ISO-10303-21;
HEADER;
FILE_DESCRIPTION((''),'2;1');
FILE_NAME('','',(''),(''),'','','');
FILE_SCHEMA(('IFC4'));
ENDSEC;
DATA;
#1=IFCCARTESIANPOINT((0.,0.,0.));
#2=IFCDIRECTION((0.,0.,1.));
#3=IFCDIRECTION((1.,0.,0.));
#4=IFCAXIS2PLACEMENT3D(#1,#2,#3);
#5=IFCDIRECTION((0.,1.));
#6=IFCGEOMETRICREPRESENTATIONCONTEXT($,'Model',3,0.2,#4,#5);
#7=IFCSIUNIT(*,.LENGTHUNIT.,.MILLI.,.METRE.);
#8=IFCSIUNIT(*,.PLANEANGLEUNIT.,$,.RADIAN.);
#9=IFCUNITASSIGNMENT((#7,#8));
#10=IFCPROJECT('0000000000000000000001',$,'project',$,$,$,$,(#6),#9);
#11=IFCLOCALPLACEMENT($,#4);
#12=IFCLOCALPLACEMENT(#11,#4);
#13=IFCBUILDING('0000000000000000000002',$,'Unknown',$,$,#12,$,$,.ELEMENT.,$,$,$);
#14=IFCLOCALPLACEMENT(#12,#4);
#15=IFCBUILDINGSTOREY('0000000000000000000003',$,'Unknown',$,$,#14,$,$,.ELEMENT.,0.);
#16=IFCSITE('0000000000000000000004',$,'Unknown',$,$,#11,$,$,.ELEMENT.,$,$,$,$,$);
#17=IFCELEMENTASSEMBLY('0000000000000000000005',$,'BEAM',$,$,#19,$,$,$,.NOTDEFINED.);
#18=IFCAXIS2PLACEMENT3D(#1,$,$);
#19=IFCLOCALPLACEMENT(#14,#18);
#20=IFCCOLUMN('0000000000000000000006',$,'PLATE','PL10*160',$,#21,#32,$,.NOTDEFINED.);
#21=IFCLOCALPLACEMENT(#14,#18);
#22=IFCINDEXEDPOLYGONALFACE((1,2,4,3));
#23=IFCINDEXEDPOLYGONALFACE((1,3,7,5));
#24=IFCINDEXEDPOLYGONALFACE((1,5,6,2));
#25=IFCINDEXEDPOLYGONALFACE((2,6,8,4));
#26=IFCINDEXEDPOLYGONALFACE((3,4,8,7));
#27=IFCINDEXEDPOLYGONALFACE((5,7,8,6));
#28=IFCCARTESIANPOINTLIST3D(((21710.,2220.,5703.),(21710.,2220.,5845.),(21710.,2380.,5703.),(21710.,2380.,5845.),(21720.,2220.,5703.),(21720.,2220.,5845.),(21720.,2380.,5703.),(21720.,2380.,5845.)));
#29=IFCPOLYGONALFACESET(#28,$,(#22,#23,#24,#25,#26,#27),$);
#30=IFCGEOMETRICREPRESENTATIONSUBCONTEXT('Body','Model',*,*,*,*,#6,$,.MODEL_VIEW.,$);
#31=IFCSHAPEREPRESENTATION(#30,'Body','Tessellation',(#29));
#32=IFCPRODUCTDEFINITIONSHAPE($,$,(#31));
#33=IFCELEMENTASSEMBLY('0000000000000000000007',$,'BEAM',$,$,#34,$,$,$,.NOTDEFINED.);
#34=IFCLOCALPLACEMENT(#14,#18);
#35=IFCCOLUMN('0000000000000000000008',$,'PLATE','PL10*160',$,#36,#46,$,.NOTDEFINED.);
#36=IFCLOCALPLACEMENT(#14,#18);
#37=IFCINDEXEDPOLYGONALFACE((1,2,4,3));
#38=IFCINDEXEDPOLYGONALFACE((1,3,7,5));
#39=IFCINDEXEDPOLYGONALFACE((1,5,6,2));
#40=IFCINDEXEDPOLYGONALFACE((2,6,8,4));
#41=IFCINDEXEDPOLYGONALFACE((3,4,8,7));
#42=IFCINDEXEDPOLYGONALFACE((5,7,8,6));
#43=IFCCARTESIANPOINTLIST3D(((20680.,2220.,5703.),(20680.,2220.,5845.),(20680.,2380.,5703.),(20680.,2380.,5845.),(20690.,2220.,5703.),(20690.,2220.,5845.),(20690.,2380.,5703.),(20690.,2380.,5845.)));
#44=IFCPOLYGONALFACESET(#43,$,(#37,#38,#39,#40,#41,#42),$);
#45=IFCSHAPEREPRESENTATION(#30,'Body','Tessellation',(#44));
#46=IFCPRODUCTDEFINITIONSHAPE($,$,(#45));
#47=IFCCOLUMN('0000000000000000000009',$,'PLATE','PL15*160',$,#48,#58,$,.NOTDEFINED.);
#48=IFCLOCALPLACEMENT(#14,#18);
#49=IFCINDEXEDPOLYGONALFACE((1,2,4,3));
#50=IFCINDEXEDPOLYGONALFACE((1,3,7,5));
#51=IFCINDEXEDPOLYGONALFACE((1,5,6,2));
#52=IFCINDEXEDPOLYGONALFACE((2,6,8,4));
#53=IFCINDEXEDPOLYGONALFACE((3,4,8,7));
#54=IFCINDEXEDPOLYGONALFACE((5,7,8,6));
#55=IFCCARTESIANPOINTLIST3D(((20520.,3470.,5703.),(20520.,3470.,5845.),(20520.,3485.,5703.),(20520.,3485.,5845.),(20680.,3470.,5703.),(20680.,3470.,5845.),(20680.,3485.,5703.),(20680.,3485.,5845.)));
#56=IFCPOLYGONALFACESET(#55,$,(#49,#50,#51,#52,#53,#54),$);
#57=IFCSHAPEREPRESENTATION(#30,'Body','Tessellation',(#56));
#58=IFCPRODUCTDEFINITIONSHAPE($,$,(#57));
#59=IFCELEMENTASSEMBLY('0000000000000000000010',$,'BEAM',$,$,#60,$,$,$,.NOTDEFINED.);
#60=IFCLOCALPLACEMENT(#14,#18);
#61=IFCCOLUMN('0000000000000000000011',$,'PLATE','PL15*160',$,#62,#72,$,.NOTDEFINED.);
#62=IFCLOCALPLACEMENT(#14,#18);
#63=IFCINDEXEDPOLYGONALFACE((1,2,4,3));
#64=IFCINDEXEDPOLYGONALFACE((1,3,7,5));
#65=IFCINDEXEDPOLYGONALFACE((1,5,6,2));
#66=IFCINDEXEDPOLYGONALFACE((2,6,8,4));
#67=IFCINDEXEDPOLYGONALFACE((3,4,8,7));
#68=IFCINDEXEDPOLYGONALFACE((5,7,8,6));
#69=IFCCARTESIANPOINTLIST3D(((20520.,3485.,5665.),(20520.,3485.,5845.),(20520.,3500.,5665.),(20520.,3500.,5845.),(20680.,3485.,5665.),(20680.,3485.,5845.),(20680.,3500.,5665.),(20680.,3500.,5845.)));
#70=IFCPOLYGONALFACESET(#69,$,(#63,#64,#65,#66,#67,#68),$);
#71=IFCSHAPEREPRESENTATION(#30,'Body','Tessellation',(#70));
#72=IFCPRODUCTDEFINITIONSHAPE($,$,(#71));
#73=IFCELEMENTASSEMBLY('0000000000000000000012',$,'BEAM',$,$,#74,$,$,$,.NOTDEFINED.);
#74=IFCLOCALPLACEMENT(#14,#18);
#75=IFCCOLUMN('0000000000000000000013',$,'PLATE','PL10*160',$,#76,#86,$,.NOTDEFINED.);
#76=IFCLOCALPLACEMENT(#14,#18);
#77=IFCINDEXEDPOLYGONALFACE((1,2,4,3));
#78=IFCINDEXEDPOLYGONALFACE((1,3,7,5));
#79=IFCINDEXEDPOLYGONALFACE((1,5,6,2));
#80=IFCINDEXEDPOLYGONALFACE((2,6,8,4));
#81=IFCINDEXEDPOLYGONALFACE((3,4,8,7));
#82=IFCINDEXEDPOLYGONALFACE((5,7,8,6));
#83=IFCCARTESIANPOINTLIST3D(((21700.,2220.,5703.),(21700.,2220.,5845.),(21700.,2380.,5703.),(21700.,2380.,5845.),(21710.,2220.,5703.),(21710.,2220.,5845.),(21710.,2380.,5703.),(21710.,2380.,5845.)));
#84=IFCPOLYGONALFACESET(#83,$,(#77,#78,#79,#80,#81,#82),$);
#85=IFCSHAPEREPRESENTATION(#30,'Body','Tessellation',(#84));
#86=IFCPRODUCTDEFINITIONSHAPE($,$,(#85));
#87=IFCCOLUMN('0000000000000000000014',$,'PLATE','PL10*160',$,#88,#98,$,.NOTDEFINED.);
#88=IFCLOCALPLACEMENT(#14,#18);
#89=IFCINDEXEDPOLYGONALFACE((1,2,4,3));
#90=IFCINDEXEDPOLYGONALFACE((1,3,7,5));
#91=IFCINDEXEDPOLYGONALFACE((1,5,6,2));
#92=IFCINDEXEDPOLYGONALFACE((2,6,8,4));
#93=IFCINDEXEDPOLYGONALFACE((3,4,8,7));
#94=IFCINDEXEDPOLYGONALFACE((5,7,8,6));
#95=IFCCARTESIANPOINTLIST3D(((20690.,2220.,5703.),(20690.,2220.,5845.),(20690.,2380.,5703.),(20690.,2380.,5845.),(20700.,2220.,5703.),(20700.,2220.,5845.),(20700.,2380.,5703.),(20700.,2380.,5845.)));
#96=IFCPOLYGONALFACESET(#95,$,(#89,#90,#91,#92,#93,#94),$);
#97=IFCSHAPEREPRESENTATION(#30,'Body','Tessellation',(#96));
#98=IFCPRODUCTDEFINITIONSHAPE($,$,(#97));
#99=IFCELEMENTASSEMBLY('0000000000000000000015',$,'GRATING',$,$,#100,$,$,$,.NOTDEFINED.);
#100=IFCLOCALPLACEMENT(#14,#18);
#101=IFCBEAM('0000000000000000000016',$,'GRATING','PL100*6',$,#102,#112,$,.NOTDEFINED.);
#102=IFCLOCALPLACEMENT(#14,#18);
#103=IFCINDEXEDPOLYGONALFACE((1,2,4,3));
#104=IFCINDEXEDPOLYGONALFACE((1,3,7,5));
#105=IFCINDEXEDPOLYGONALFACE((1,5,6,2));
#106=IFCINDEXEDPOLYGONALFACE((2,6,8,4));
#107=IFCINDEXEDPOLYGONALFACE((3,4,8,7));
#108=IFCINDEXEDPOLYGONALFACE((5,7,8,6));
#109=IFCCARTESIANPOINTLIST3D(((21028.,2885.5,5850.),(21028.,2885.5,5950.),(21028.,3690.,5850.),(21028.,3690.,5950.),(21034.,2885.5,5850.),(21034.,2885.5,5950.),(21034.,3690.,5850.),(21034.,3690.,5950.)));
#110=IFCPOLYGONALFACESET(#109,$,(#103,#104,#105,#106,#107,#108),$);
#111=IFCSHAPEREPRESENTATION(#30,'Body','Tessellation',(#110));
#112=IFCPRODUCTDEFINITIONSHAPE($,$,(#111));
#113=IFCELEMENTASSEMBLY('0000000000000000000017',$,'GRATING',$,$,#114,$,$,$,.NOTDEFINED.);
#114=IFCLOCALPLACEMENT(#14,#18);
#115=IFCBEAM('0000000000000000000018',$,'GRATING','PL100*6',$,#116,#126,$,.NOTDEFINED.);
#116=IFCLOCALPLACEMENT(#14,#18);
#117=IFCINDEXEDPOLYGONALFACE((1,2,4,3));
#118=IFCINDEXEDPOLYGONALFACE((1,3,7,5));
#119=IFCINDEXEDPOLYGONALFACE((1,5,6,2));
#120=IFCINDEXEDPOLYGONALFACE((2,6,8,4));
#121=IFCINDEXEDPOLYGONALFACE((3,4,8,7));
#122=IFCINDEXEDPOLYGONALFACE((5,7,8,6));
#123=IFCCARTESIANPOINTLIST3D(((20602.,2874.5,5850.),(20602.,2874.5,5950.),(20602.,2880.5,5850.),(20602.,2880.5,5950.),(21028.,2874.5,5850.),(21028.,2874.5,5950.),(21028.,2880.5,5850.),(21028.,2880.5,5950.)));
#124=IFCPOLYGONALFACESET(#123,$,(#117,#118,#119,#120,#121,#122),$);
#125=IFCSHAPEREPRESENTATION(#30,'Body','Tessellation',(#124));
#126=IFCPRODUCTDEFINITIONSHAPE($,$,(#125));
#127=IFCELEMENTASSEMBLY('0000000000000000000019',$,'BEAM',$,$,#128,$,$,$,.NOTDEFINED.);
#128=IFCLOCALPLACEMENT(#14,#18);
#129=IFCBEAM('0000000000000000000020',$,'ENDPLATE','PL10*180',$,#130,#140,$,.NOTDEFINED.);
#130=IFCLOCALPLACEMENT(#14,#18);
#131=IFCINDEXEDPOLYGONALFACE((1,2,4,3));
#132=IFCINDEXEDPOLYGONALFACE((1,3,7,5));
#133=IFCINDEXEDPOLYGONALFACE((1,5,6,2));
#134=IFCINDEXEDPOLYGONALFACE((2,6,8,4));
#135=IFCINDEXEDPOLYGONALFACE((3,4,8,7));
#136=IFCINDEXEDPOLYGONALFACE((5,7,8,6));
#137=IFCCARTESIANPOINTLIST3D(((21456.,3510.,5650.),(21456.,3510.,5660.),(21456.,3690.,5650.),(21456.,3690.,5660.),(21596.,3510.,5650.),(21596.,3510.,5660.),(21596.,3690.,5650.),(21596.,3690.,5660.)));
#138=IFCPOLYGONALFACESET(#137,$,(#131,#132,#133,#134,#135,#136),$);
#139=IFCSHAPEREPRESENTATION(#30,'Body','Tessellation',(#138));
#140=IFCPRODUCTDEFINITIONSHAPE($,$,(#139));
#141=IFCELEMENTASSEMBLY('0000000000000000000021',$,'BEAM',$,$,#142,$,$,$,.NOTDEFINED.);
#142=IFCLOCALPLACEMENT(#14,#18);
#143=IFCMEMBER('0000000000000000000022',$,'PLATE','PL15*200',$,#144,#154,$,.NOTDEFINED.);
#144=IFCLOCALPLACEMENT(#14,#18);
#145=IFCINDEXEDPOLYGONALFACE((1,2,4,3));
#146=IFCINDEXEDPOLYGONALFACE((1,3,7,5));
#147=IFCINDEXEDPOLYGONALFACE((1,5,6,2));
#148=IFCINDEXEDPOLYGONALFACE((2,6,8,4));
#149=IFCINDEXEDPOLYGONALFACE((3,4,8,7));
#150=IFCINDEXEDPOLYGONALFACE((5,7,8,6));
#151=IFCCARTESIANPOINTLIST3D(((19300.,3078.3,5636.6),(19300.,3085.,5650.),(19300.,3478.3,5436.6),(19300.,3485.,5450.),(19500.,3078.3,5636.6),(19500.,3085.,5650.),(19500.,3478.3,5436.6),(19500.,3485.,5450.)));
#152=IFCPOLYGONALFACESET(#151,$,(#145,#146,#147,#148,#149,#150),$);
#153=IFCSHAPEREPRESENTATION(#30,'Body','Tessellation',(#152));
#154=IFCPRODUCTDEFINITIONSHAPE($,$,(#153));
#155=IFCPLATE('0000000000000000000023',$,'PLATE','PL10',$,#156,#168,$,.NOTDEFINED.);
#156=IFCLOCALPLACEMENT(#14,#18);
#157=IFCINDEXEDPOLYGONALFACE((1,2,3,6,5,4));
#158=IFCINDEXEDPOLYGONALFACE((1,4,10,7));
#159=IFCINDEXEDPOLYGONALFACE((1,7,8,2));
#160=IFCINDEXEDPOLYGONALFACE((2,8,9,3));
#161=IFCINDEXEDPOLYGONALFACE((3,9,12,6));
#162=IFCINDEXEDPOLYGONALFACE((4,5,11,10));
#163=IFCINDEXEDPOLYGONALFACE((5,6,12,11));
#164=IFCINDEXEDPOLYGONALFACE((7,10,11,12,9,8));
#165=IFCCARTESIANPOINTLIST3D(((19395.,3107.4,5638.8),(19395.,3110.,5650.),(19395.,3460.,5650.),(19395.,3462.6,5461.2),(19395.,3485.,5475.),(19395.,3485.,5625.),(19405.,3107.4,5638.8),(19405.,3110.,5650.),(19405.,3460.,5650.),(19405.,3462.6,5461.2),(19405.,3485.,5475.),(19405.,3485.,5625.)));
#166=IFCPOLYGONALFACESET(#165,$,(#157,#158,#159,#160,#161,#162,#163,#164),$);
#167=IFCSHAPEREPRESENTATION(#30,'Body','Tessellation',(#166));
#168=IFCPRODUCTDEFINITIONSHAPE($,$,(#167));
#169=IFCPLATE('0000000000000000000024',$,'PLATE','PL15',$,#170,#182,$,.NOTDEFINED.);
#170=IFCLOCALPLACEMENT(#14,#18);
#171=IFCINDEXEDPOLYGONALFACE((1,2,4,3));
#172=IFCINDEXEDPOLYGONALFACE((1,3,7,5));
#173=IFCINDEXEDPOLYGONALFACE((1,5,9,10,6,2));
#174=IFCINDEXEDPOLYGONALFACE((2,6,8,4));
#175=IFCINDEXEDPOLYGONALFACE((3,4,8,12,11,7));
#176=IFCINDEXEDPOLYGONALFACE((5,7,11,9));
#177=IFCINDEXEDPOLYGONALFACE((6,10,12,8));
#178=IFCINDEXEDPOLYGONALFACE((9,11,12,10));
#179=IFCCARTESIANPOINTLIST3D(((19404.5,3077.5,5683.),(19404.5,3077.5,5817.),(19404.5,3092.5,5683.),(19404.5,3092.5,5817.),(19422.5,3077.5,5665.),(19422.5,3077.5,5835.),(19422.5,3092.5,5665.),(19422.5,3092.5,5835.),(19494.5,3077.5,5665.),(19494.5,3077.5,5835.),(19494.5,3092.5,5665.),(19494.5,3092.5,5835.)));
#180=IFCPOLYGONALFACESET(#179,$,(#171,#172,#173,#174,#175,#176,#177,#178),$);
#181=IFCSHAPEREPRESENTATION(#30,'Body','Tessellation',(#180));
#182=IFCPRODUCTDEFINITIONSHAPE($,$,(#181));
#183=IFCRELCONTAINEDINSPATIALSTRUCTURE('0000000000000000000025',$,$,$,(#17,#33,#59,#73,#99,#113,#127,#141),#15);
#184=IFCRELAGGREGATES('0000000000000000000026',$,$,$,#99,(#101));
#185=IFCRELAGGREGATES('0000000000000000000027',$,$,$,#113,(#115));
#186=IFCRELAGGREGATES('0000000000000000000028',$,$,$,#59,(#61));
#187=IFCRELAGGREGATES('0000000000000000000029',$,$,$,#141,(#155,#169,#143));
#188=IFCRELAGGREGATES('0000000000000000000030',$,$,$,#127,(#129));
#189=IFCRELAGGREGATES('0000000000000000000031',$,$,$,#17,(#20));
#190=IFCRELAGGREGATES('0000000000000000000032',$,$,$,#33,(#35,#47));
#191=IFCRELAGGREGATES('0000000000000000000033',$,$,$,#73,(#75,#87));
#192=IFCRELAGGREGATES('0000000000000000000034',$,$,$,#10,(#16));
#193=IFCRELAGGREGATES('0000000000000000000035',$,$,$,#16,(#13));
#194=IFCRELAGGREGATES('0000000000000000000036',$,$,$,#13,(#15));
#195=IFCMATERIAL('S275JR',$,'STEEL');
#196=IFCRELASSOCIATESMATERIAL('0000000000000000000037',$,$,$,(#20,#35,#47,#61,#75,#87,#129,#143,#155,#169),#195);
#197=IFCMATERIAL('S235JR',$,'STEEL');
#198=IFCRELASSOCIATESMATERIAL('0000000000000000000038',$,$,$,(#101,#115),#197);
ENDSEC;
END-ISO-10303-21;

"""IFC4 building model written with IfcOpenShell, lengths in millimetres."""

from ifc_helpers import new_model, si_unit, direction, frame, origin_with_axes, place, context, subcontext, project, spatial, line, indexed_curve, outline, extrude, material, element, aggregate, save


model = new_model("IFC4")

# Units and contexts
model_context = context("Model", 3, precision=0.2, world=origin_with_axes(), true_north=direction((0.0, 1.0)))
body_context = subcontext(model_context, "Body", "Model", "MODEL_VIEW")
ifc_project = project(units=[si_unit("LENGTHUNIT", "METRE", prefix="MILLI"), si_unit("PLANEANGLEUNIT", "RADIAN")], contexts=[model_context])

# Site, building, storey
site_placement = place(None, origin_with_axes())
site = spatial("IfcSite", under=ifc_project, at=site_placement, Name="Unknown", CompositionType="ELEMENT")
building_placement = place(site_placement, origin_with_axes())
building = spatial("IfcBuilding", under=site, at=building_placement, Name="Unknown", CompositionType="ELEMENT")
storey_placement = place(building_placement, origin_with_axes())
storey = spatial("IfcBuildingStorey", under=building, at=storey_placement, Name="Unknown", CompositionType="ELEMENT", Elevation=0.0)

# Element assembly, column
assembly_1_placement = place(storey_placement, frame((21800.0, 3600.0, 5774.0), z_axis=(-1.0, 0.0, 0.0), x_axis=(-0.000002, -1.0, 0.0)))
assembly_1 = element("IfcElementAssembly", 1, at=assembly_1_placement, inside=storey, Name="BEAM", PredefinedType="NOTDEFINED")
ifc_material_1 = material(Name="S275JR", Category="STEEL")
column_1_placement = place(assembly_1_placement, frame((1300.0, -71.0, 85.0), z_axis=(0.0, 0.0, 1.0), x_axis=(0.0, 1.0, 0.0)))
column_1 = element("IfcColumn", 2, at=column_1_placement, material=ifc_material_1, Name="PLATE", Description="PL10*160", PredefinedType="NOTDEFINED", context=body_context, shape_type="SolidModel", body=[
    extrude(outline(indexed_curve([(-5.0, -80.0), (5.0, -80.0), (5.0, 80.0), (-5.0, 80.0)], segments=[line(1, 2, 3, 4, 1)])), frame((0.0, 0.0, 0.0), z_axis=(-1.0, 0.0, 0.0), x_axis=(0.0, 0.0, 1.0)), (0.0, -0.000002, -1.0), 142.0),
])

# Element assembly, columns
assembly_2_placement = place(storey_placement, frame((20600.0, 3600.0, 5774.0), z_axis=(-1.0, 0.0, 0.0), x_axis=(-0.000002, -1.0, 0.0)))
assembly_2 = element("IfcElementAssembly", 3, at=assembly_2_placement, inside=storey, Name="BEAM", PredefinedType="NOTDEFINED")
column_2_placement = place(assembly_2_placement, frame((1300.0, -71.0, -85.0), z_axis=(0.0, -0.000002, -1.0), x_axis=(0.0, 1.0, 0.0)))
column_2 = element("IfcColumn", 4, at=column_2_placement, material=ifc_material_1, Name="PLATE", Description="PL10*160", PredefinedType="NOTDEFINED", context=body_context, shape_type="SolidModel", body=[
    extrude(outline(indexed_curve([(-5.0, -80.0), (5.0, -80.0), (5.0, 80.0), (-5.0, 80.0)], segments=[line(1, 2, 3, 4, 1)])), frame((0.0, 0.0, 0.0), z_axis=(-1.0, 0.0, 0.0), x_axis=(0.0, 0.0, 1.0)), (0.0, -0.000002, -1.0), 142.0),
])
column_3_placement = place(assembly_2_placement, frame((122.5, -71.0, 0.0), z_axis=(1.0, 0.0, 0.0), x_axis=(0.0, 1.0, 0.0)))
column_3 = element("IfcColumn", 5, at=column_3_placement, material=ifc_material_1, Name="PLATE", Description="PL15*160", PredefinedType="NOTDEFINED", context=body_context, shape_type="SolidModel", body=[
    extrude(outline(indexed_curve([(-7.5, -80.0), (7.5, -80.0), (7.5, 80.0), (-7.5, 80.0)], segments=[line(1, 2, 3, 4, 1)])), frame((0.0, 0.0, 0.0), z_axis=(-1.0, 0.0, 0.0), x_axis=(0.0, 0.0, 1.0)), (0.0, -0.000002, -1.0), 142.0),
])

# Element assembly, column
assembly_3_placement = place(storey_placement, frame((19400.0, 3600.0, 5755.0), z_axis=(-0.000002, -1.0, 0.0), x_axis=(1.0, 0.0, 0.0)))
assembly_3 = element("IfcElementAssembly", 6, at=assembly_3_placement, inside=storey, Name="BEAM", PredefinedType="NOTDEFINED")
column_4_placement = place(assembly_3_placement, frame((1200.0, -90.0, 107.5), z_axis=(0.0, 0.0, 1.0), x_axis=(0.0, 1.0, 0.0)))
column_4 = element("IfcColumn", 7, at=column_4_placement, material=ifc_material_1, Name="PLATE", Description="PL15*160", PredefinedType="NOTDEFINED", context=body_context, shape_type="SolidModel", body=[
    extrude(outline(indexed_curve([(-7.5, -80.0), (7.5, -80.0), (7.5, 80.0), (-7.5, 80.0)], segments=[line(1, 2, 3, 4, 1)])), frame((0.0, 0.0, 0.0), z_axis=(-1.0, 0.0, 0.0), x_axis=(0.0, 0.0, 1.0)), (0.0, -0.000002, -1.0), 180.0),
])

# Element assembly, columns
assembly_4_placement = place(storey_placement, frame((20600.0, 2300.0, 5774.0), z_axis=(-0.000002, -1.0, 0.0), x_axis=(1.0, 0.0, 0.0)))
assembly_4 = element("IfcElementAssembly", 8, at=assembly_4_placement, inside=storey, Name="BEAM", PredefinedType="NOTDEFINED")
column_5_placement = place(assembly_4_placement, frame((1105.0, -71.0, 0.0), z_axis=(-1.0, 0.0, 0.0), x_axis=(0.0, 1.0, 0.0)))
column_5 = element("IfcColumn", 9, at=column_5_placement, material=ifc_material_1, Name="PLATE", Description="PL10*160", PredefinedType="NOTDEFINED", context=body_context, shape_type="SolidModel", body=[
    extrude(outline(indexed_curve([(-5.0, -80.0), (5.0, -80.0), (5.0, 80.0), (-5.0, 80.0)], segments=[line(1, 2, 3, 4, 1)])), frame((0.0, 0.0, 0.0), z_axis=(-1.0, 0.0, 0.0), x_axis=(0.0, 0.0, 1.0)), (0.0, -0.000002, -1.0), 142.0),
])
column_6_placement = place(assembly_4_placement, frame((95.0, -71.0, 0.0), z_axis=(1.0, 0.0, 0.0), x_axis=(0.0, 1.0, 0.0)))
column_6 = element("IfcColumn", 10, at=column_6_placement, material=ifc_material_1, Name="PLATE", Description="PL10*160", PredefinedType="NOTDEFINED", context=body_context, shape_type="SolidModel", body=[
    extrude(outline(indexed_curve([(-5.0, -80.0), (5.0, -80.0), (5.0, 80.0), (-5.0, 80.0)], segments=[line(1, 2, 3, 4, 1)])), frame((0.0, 0.0, 0.0), z_axis=(-1.0, 0.0, 0.0), x_axis=(0.0, 0.0, 1.0)), (0.0, -0.000002, -1.0), 142.0),
])

# Element assemblies, beams
assembly_5_placement = place(storey_placement, frame((21034.0, 3690.0, 5865.0), z_axis=(0.0, -0.000002, -1.0), x_axis=(1.0, 0.0, 0.0)))
assembly_5 = element("IfcElementAssembly", 11, at=assembly_5_placement, inside=storey, Name="GRATING", PredefinedType="NOTDEFINED")
ifc_material_2 = material(Name="S235JR", Category="STEEL")
beam_1_placement = place(assembly_5_placement, frame((-3.0, 804.5, -35.0), z_axis=(1.0, 0.0, 0.0), x_axis=(0.0, -1.0, 0.000002)))
beam_1 = element("IfcBeam", 12, at=beam_1_placement, material=ifc_material_2, Name="GRATING", Description="PL100*6", PredefinedType="NOTDEFINED", context=body_context, shape_type="SolidModel", body=[
    extrude(outline(indexed_curve([(-3.0, -50.0), (3.0, -50.0), (3.0, 50.0), (-3.0, 50.0)], segments=[line(1, 2, 3, 4, 1)])), frame((0.0, 0.0, 0.0), z_axis=(-1.0, 0.0, 0.0), x_axis=(0.0, 0.0, 1.0)), (0.0, -0.000002, -1.0), 804.5),
])
aggregate(assembly_5, [beam_1])
assembly_6_placement = place(storey_placement, frame((20602.0, 2874.5, 5865.0), z_axis=(0.0, -0.000002, -1.0), x_axis=(1.0, 0.0, 0.0)))
assembly_6 = element("IfcElementAssembly", 13, at=assembly_6_placement, inside=storey, Name="GRATING", PredefinedType="NOTDEFINED")
beam_2_placement = place(assembly_6_placement, frame((0.0, -3.0, -35.0), z_axis=(0.0, 1.0, 0.0), x_axis=(1.0, 0.0, 0.0)))
beam_2 = element("IfcBeam", 14, at=beam_2_placement, material=ifc_material_2, Name="GRATING", Description="PL100*6", PredefinedType="NOTDEFINED", context=body_context, shape_type="SolidModel", body=[
    extrude(outline(indexed_curve([(-3.0, -50.0), (3.0, -50.0), (3.0, 50.0), (-3.0, 50.0)], segments=[line(1, 2, 3, 4, 1)])), frame((0.0, 0.0, 0.0), z_axis=(-1.0, 0.0, 0.0), x_axis=(0.0, 0.0, 1.0)), (0.0, -0.000002, -1.0), 426.0),
])
aggregate(assembly_6, [beam_2])
assembly_7_placement = place(storey_placement, frame((21526.0, 3600.0, 5609.0), z_axis=(-0.000002, -1.0, 0.0), x_axis=(0.0, -0.000002, -1.0)))
assembly_7 = element("IfcElementAssembly", 15, at=assembly_7_placement, inside=storey, Name="BEAM", PredefinedType="NOTDEFINED")
beam_3_placement = place(assembly_7_placement, frame((-46.0, -70.0, 0.0), z_axis=(1.0, 0.0, 0.0), x_axis=(0.0, 1.0, 0.0)))
beam_3 = element("IfcBeam", 16, at=beam_3_placement, material=ifc_material_1, Name="ENDPLATE", Description="PL10*180", PredefinedType="NOTDEFINED", context=body_context, shape_type="SolidModel", body=[
    extrude(outline(indexed_curve([(-5.0, -90.0), (5.0, -90.0), (5.0, 90.0), (-5.0, 90.0)], segments=[line(1, 2, 3, 4, 1)])), frame((0.0, 0.0, 0.0), z_axis=(-1.0, 0.0, 0.0), x_axis=(0.0, 0.0, 1.0)), (0.0, -0.000002, -1.0), 140.0),
])

# Element assembly, member, plates
assembly_8_placement = place(storey_placement, frame((19400.0, 0.0, 5750.0), z_axis=(1.0, 0.0, 0.0), x_axis=(0.0, 1.0, 0.0)))
assembly_8 = element("IfcElementAssembly", 17, at=assembly_8_placement, inside=storey, Name="BEAM", PredefinedType="NOTDEFINED")
member_placement = place(assembly_8_placement, frame((3481.6, -306.7, 0.0), z_axis=(-0.447214, -0.894427, 0.0), x_axis=(-0.894427, 0.447214, 0.0)))
member = element("IfcMember", 18, at=member_placement, material=ifc_material_1, Name="PLATE", Description="PL15*200", PredefinedType="NOTDEFINED", context=body_context, shape_type="SolidModel", body=[
    extrude(outline(indexed_curve([(-7.5, -100.0), (7.5, -100.0), (7.5, 100.0), (-7.5, 100.0)], segments=[line(1, 2, 3, 4, 1)])), frame((0.0, 0.0, 0.0), z_axis=(-1.0, 0.0, 0.0), x_axis=(0.0, 0.0, 1.0)), (0.0, -0.000002, -1.0), 447.2),
])
plate_1_placement = place(assembly_8_placement, frame((3485.0, -300.0, 0.0), z_axis=(0.0, 0.0, 1.0), x_axis=(0.0, 1.0, 0.0)))
plate_1 = element("IfcPlate", 19, at=plate_1_placement, material=ifc_material_1, Name="PLATE", Description="PL10", PredefinedType="NOTDEFINED", context=body_context, shape_type="SolidModel", body=[
    extrude(outline(indexed_curve([(11.2, 22.4), (25.0, 0.0), (175.0, 0.0), (200.0, 25.0), (200.0, 375.0), (188.8, 377.6)], segments=[line(1, 2, 3, 4, 5, 6, 1)])), frame((0.0, 0.0, 5.0), z_axis=(0.0, 0.0, 1.0), x_axis=(1.0, 0.0, 0.0)), (0.0, -0.000002, -1.0), 10.0),
])
plate_2_placement = place(assembly_8_placement, frame((3085.0, -85.0, 4.5), z_axis=(-1.0, 0.0, 0.0), x_axis=(0.0, 0.0, 1.0)))
plate_2 = element("IfcPlate", 20, at=plate_2_placement, material=ifc_material_1, Name="PLATE", Description="PL15", PredefinedType="NOTDEFINED", context=body_context, shape_type="SolidModel", body=[
    extrude(outline(indexed_curve([(0.0, 18.0), (18.0, 0.0), (90.0, 0.0), (90.0, 170.0), (18.0, 170.0), (0.0, 152.0)], segments=[line(1, 2, 3, 4, 5, 6, 1)])), frame((0.0, 0.0, 7.5), z_axis=(0.0, 0.0, 1.0), x_axis=(1.0, 0.0, 0.0)), (0.0, -0.000002, -1.0), 15.0),
])

aggregate(assembly_3, [column_4])

aggregate(assembly_8, [plate_1, plate_2, member])
aggregate(assembly_7, [beam_3])
aggregate(assembly_1, [column_1])
aggregate(assembly_2, [column_2, column_3])
aggregate(assembly_4, [column_5, column_6])

save(model, "model.ifc")
